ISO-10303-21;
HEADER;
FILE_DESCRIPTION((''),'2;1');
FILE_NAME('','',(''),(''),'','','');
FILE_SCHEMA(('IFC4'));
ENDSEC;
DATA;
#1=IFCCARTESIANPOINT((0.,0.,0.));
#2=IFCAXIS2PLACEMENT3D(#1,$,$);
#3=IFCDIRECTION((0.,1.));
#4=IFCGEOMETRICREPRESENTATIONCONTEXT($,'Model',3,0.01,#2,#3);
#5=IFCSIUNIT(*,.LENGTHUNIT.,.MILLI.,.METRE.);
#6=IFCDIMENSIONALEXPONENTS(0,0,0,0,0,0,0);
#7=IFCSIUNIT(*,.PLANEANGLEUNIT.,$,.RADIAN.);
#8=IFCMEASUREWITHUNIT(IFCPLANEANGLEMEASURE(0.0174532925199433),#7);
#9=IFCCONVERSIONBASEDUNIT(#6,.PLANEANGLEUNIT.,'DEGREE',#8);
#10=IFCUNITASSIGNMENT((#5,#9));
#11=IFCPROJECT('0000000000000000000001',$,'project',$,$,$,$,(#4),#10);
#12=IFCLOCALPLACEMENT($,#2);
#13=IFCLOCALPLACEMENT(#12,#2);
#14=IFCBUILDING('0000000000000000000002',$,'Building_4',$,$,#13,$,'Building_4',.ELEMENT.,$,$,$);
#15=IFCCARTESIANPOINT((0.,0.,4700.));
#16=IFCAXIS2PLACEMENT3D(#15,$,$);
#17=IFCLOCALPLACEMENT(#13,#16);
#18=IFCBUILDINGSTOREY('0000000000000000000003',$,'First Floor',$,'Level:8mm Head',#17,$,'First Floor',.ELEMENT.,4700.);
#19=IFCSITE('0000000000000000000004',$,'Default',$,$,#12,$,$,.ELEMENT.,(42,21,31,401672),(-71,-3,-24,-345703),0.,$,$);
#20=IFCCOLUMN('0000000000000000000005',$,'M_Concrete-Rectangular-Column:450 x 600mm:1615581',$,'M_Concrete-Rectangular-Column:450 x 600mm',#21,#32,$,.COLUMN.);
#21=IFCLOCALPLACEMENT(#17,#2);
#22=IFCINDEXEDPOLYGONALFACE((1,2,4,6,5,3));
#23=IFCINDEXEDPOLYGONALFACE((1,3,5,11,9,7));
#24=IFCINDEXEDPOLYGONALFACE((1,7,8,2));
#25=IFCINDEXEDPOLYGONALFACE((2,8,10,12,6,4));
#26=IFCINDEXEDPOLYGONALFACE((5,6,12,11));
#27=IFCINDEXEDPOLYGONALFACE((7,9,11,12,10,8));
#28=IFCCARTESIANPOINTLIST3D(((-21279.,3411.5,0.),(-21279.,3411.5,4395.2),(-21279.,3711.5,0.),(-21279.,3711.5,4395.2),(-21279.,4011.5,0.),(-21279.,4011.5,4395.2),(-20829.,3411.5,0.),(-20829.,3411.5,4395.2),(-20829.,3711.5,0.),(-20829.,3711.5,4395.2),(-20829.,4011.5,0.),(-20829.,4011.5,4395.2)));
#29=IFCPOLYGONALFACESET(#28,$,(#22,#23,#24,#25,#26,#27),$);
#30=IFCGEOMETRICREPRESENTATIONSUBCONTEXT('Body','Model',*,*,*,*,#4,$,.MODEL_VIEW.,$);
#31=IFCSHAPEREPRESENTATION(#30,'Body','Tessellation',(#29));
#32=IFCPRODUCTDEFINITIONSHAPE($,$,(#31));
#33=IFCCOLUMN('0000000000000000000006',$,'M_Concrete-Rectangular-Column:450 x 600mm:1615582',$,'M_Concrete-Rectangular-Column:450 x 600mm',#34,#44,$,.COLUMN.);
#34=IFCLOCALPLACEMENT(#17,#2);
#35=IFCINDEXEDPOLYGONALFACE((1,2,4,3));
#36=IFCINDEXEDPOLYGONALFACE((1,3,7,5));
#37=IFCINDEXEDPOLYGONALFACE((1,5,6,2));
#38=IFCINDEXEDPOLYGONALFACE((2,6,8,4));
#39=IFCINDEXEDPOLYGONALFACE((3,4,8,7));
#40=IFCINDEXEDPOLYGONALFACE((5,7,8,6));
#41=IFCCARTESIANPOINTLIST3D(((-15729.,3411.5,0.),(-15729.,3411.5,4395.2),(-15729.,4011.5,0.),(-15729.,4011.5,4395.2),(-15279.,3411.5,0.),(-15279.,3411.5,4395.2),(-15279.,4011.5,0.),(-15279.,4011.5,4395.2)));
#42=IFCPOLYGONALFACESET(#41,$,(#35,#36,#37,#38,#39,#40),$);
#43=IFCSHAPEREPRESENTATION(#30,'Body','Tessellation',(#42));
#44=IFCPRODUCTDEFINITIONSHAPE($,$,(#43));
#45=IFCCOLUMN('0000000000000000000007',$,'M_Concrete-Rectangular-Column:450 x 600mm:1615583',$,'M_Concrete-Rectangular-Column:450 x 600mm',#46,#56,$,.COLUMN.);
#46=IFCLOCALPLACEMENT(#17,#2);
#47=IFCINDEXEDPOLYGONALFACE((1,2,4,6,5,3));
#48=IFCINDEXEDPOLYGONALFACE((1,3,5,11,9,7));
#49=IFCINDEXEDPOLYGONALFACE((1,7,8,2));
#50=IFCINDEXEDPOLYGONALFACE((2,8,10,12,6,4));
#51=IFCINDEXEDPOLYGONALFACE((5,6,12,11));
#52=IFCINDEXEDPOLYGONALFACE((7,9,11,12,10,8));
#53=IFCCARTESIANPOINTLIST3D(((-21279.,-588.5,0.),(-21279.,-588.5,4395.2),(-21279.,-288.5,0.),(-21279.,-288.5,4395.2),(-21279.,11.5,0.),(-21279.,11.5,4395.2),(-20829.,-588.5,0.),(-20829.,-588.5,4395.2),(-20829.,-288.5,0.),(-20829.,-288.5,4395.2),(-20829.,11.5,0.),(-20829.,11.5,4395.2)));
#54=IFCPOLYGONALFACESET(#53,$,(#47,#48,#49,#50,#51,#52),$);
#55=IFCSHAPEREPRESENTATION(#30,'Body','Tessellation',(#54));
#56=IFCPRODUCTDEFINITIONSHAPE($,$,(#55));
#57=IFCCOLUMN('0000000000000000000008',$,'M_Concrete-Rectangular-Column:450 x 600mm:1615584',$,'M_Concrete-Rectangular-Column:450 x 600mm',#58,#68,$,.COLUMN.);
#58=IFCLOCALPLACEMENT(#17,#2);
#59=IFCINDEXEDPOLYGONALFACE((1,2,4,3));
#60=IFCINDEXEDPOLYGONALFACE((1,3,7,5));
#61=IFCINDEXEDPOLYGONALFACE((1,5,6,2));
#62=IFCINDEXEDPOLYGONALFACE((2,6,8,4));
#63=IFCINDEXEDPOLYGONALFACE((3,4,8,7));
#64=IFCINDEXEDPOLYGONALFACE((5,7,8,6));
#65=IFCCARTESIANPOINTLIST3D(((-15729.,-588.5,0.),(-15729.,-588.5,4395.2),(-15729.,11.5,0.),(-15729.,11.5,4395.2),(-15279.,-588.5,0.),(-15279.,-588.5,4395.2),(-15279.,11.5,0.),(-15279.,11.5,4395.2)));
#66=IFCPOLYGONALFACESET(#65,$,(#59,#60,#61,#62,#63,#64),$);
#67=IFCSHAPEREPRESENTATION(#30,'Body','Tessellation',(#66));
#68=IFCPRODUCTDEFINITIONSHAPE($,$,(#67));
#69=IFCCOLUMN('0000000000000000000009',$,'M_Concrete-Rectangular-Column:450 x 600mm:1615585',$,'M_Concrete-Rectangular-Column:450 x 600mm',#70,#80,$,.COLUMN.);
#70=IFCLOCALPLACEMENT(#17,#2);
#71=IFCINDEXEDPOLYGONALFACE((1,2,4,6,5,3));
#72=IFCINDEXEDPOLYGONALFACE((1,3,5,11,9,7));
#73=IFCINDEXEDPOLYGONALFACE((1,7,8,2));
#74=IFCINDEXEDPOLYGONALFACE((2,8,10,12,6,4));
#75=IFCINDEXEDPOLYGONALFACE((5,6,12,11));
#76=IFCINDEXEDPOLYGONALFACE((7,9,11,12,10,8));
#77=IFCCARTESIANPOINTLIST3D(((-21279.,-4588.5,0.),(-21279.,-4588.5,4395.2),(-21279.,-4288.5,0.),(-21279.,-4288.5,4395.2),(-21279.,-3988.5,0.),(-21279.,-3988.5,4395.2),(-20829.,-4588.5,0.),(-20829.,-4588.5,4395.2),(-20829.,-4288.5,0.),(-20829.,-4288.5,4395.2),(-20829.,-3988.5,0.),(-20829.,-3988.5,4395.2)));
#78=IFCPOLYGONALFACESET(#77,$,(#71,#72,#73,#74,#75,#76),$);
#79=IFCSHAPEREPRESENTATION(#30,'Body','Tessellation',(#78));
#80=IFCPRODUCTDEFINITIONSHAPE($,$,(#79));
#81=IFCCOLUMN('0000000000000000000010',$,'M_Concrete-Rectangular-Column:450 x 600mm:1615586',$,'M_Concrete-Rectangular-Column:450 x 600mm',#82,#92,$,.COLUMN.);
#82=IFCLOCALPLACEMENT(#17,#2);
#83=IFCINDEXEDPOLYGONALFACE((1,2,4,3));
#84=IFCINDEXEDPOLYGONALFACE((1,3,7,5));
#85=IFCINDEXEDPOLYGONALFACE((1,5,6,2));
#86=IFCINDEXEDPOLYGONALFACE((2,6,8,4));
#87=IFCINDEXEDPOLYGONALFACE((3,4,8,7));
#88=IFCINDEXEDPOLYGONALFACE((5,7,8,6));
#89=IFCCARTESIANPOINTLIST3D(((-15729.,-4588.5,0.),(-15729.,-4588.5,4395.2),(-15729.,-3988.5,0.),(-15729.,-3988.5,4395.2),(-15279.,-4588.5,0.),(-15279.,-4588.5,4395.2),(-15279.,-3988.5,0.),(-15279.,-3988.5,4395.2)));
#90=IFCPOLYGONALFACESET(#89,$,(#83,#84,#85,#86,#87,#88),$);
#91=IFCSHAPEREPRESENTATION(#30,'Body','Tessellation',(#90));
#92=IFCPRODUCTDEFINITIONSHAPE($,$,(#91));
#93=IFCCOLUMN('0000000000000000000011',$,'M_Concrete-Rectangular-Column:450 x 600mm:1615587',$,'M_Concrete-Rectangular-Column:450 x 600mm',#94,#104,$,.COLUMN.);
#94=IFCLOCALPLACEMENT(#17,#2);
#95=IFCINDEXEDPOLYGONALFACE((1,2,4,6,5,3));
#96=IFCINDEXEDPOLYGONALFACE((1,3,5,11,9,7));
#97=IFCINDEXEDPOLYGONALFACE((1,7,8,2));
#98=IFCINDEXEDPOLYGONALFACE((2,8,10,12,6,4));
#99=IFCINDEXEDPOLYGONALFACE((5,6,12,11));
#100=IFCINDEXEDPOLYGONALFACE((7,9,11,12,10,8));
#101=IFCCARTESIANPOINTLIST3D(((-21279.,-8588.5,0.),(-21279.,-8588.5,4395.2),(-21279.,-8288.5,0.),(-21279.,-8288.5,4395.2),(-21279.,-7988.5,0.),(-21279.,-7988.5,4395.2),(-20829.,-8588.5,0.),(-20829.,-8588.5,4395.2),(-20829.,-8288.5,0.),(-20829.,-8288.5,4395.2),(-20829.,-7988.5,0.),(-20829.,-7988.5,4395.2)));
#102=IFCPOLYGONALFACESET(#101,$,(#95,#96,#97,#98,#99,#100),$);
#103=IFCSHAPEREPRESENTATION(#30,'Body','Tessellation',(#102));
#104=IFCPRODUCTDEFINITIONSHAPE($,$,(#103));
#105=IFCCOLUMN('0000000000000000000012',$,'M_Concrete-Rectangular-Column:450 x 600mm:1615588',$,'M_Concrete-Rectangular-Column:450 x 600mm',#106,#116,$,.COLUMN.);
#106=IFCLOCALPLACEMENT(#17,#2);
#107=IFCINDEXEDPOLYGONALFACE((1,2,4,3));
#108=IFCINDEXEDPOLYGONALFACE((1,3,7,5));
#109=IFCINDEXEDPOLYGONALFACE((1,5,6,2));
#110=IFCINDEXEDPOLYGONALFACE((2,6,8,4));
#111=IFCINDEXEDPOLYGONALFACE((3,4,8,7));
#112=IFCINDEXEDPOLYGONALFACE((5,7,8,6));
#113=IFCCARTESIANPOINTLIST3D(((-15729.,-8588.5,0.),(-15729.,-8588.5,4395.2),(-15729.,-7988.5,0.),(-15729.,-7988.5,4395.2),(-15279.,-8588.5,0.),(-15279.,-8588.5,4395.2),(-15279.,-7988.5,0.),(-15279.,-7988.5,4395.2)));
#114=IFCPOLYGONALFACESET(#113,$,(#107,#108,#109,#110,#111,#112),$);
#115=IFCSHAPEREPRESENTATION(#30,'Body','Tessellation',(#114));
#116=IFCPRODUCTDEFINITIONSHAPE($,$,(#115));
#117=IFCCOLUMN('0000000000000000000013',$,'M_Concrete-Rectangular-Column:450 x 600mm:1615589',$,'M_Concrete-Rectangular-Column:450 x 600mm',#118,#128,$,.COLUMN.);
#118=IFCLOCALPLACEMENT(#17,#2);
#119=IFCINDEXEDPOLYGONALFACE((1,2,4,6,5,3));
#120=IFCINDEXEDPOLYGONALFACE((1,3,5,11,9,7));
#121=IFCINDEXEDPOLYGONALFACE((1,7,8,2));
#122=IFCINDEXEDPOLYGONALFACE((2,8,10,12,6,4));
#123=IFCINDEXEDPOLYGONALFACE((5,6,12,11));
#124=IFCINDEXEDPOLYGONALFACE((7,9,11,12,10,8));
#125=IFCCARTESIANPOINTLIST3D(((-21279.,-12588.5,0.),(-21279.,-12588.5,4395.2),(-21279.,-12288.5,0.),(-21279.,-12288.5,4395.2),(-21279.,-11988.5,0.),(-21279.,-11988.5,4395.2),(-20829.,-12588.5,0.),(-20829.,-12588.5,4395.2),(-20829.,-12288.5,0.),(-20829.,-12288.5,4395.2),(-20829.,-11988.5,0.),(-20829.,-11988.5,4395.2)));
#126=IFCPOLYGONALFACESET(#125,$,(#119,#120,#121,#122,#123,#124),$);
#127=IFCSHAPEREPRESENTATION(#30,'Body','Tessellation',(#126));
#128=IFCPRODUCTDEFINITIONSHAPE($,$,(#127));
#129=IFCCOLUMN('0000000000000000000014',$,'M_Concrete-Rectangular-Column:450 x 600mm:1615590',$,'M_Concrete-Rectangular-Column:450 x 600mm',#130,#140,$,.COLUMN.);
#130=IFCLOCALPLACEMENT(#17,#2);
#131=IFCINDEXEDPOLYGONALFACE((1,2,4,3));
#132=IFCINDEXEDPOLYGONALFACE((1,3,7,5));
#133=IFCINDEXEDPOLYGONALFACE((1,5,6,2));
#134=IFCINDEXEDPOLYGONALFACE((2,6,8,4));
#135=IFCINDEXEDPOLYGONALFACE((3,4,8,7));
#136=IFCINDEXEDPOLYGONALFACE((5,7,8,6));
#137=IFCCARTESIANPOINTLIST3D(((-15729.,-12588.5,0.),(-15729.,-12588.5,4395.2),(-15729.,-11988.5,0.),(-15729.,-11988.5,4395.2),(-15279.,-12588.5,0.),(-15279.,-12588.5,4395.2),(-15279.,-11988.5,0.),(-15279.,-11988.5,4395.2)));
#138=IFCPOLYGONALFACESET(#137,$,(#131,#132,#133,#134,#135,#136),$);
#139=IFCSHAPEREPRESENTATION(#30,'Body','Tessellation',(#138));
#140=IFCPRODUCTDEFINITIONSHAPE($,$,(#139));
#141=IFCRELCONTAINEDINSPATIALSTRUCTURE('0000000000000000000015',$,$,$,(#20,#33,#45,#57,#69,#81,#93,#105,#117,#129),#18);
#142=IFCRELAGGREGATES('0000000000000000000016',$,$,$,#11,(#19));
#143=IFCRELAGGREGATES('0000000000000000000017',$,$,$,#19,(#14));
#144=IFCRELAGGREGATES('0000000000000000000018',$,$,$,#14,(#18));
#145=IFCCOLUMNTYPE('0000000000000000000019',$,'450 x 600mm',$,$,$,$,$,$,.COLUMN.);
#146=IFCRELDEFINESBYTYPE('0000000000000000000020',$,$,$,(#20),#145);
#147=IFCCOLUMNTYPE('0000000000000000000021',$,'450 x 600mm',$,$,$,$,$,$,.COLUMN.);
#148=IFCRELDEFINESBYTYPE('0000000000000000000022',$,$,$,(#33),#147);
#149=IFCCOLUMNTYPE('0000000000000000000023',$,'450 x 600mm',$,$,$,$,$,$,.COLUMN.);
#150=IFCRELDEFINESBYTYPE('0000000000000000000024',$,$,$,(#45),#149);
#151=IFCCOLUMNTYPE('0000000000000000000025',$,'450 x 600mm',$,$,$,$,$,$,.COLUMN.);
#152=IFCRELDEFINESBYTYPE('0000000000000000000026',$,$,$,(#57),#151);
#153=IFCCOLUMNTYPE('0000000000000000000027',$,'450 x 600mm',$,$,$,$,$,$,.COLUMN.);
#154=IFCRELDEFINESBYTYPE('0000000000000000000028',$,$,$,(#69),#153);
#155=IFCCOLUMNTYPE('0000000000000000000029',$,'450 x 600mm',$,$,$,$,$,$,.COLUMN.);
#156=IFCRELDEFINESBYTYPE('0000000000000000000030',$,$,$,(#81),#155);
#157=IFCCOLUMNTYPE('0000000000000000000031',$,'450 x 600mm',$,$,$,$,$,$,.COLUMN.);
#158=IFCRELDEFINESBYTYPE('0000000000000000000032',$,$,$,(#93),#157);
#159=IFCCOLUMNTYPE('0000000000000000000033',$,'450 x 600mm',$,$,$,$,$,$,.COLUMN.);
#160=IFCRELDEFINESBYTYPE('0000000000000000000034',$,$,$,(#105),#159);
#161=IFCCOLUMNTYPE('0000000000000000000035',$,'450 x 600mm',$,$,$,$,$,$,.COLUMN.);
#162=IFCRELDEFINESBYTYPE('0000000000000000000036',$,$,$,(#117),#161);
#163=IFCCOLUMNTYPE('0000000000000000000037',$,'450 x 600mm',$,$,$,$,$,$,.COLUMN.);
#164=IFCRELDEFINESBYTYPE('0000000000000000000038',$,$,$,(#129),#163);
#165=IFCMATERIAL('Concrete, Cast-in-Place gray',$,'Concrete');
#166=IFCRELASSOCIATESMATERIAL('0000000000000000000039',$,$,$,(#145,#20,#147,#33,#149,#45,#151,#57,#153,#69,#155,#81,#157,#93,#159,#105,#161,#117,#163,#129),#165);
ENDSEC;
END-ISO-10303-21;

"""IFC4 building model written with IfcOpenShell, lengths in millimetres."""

from ifc_helpers import new_model, entity, si_unit, converted_unit, direction, frame, origin, place, context, subcontext, project, spatial, indexed_curve, outline, extrude, source, transform, mapped, material, type_object, type_shapes, element, save


model = new_model("IFC4")

# Units and contexts
model_context = context("Model", 3, precision=0.01, world=origin(), true_north=direction((0.0, 1.0)))
body_context = subcontext(model_context, "Body", "Model", "MODEL_VIEW")
ifc_project = project(units=[si_unit("LENGTHUNIT", "METRE", prefix="MILLI"), converted_unit("PLANEANGLEUNIT", "DEGREE", entity("IfcPlaneAngleMeasure", 0.0174532925199433), si_unit("PLANEANGLEUNIT", "RADIAN"), dimensions=[0, 0, 0, 0, 0, 0, 0])], contexts=[model_context])

# Site, building, storey
site_placement = place(None, origin())
site = spatial("IfcSite", under=ifc_project, at=site_placement, Name="Default", CompositionType="ELEMENT", RefLatitude=(42, 21, 31, 401672), RefLongitude=(-71, -3, -24, -345703), RefElevation=0.0)
building_placement = place(site_placement, origin())
building = spatial("IfcBuilding", under=site, at=building_placement, Name="Building_4", LongName="Building_4", CompositionType="ELEMENT")
storey_placement = place(building_placement, frame((0.0, 0.0, 4700.0)))
storey = spatial("IfcBuildingStorey", under=building, at=storey_placement, Name="First Floor", ObjectType="Level:8mm Head", LongName="First Floor", CompositionType="ELEMENT", Elevation=4700.0)

# Columns
ifc_material = material(Name="Concrete, Cast-in-Place gray", Category="Concrete")
column_type_1 = type_object("IfcColumnType", Name="450 x 600mm", PredefinedType="COLUMN", material=ifc_material)
shared_shape_1 = source(origin(), body_context, "Body", "SweptSolid", [
    extrude(outline(indexed_curve([(-2197.6, -300.0), (2197.6, -300.0), (2197.6, 0.0), (2197.6, 300.0), (-2197.6, 300.0), (-2197.6, 0.0), (-2197.6, -300.0)], self_intersect=False)), frame((-21279.0, 3711.5, 6897.6), z_axis=(1.0, 0.0, 0.0), x_axis=(0.0, 0.0, 1.0)), (0.0, 0.0, 1.0), 450.0),
])
type_shapes(column_type_1, [shared_shape_1])
column_1_placement = place(storey_placement, frame((0.0, 0.0, -4700.0)))
element("IfcColumn", 1, at=column_1_placement, inside=storey, type_object=column_type_1, material=ifc_material, Name="M_Concrete-Rectangular-Column:450 x 600mm:1615581", ObjectType="M_Concrete-Rectangular-Column:450 x 600mm", PredefinedType="COLUMN", context=body_context, shape_type="MappedRepresentation", body=[
    mapped(shared_shape_1, transform((0.0, 0.0, 0.0), scale=1.0)),
])
column_type_2 = type_object("IfcColumnType", Name="450 x 600mm", PredefinedType="COLUMN", material=ifc_material)
shared_shape_2 = source(origin(), body_context, "Body", "SweptSolid", [
    extrude(outline(indexed_curve([(-2197.6, -300.0), (2197.6, -300.0), (2197.6, 300.0), (-2197.6, 300.0), (-2197.6, -300.0)], self_intersect=False)), frame((-15729.0, 3711.5, 6897.6), z_axis=(1.0, 0.0, 0.0), x_axis=(0.0, 0.0, 1.0)), (0.0, 0.0, 1.0), 450.0),
])
type_shapes(column_type_2, [shared_shape_2])
column_2_placement = place(storey_placement, frame((0.0, 0.0, -4700.0)))
element("IfcColumn", 2, at=column_2_placement, inside=storey, type_object=column_type_2, material=ifc_material, Name="M_Concrete-Rectangular-Column:450 x 600mm:1615582", ObjectType="M_Concrete-Rectangular-Column:450 x 600mm", PredefinedType="COLUMN", context=body_context, shape_type="MappedRepresentation", body=[
    mapped(shared_shape_2, transform((0.0, 0.0, 0.0), scale=1.0)),
])
column_type_3 = type_object("IfcColumnType", Name="450 x 600mm", PredefinedType="COLUMN", material=ifc_material)
shared_shape_3 = source(origin(), body_context, "Body", "SweptSolid", [
    extrude(outline(indexed_curve([(-2197.6, -300.0), (2197.6, -300.0), (2197.6, 0.0), (2197.6, 300.0), (-2197.6, 300.0), (-2197.6, 0.0), (-2197.6, -300.0)], self_intersect=False)), frame((-21279.0, -288.5, 6897.6), z_axis=(1.0, 0.0, 0.0), x_axis=(0.0, 0.0, 1.0)), (0.0, 0.0, 1.0), 450.0),
])
type_shapes(column_type_3, [shared_shape_3])
column_3_placement = place(storey_placement, frame((0.0, 0.0, -4700.0)))
element("IfcColumn", 3, at=column_3_placement, inside=storey, type_object=column_type_3, material=ifc_material, Name="M_Concrete-Rectangular-Column:450 x 600mm:1615583", ObjectType="M_Concrete-Rectangular-Column:450 x 600mm", PredefinedType="COLUMN", context=body_context, shape_type="MappedRepresentation", body=[
    mapped(shared_shape_3, transform((0.0, 0.0, 0.0), scale=1.0)),
])
column_type_4 = type_object("IfcColumnType", Name="450 x 600mm", PredefinedType="COLUMN", material=ifc_material)
shared_shape_4 = source(origin(), body_context, "Body", "SweptSolid", [
    extrude(outline(indexed_curve([(-2197.6, -300.0), (2197.6, -300.0), (2197.6, 300.0), (-2197.6, 300.0), (-2197.6, -300.0)], self_intersect=False)), frame((-15729.0, -288.5, 6897.6), z_axis=(1.0, 0.0, 0.0), x_axis=(0.0, 0.0, 1.0)), (0.0, 0.0, 1.0), 450.0),
])
type_shapes(column_type_4, [shared_shape_4])
column_4_placement = place(storey_placement, frame((0.0, 0.0, -4700.0)))
element("IfcColumn", 4, at=column_4_placement, inside=storey, type_object=column_type_4, material=ifc_material, Name="M_Concrete-Rectangular-Column:450 x 600mm:1615584", ObjectType="M_Concrete-Rectangular-Column:450 x 600mm", PredefinedType="COLUMN", context=body_context, shape_type="MappedRepresentation", body=[
    mapped(shared_shape_4, transform((0.0, 0.0, 0.0), scale=1.0)),
])
column_type_5 = type_object("IfcColumnType", Name="450 x 600mm", PredefinedType="COLUMN", material=ifc_material)
shared_shape_5 = source(origin(), body_context, "Body", "SweptSolid", [
    extrude(outline(indexed_curve([(-2197.6, -300.0), (2197.6, -300.0), (2197.6, 0.0), (2197.6, 300.0), (-2197.6, 300.0), (-2197.6, 0.0), (-2197.6, -300.0)], self_intersect=False)), frame((-21279.0, -4288.5, 6897.6), z_axis=(1.0, 0.0, 0.0), x_axis=(0.0, 0.0, 1.0)), (0.0, 0.0, 1.0), 450.0),
])
type_shapes(column_type_5, [shared_shape_5])
column_5_placement = place(storey_placement, frame((0.0, 0.0, -4700.0)))
element("IfcColumn", 5, at=column_5_placement, inside=storey, type_object=column_type_5, material=ifc_material, Name="M_Concrete-Rectangular-Column:450 x 600mm:1615585", ObjectType="M_Concrete-Rectangular-Column:450 x 600mm", PredefinedType="COLUMN", context=body_context, shape_type="MappedRepresentation", body=[
    mapped(shared_shape_5, transform((0.0, 0.0, 0.0), scale=1.0)),
])
column_type_6 = type_object("IfcColumnType", Name="450 x 600mm", PredefinedType="COLUMN", material=ifc_material)
shared_shape_6 = source(origin(), body_context, "Body", "SweptSolid", [
    extrude(outline(indexed_curve([(-2197.6, -300.0), (2197.6, -300.0), (2197.6, 300.0), (-2197.6, 300.0), (-2197.6, -300.0)], self_intersect=False)), frame((-15729.0, -4288.5, 6897.6), z_axis=(1.0, 0.0, 0.0), x_axis=(0.0, 0.0, 1.0)), (0.0, 0.0, 1.0), 450.0),
])
type_shapes(column_type_6, [shared_shape_6])
column_6_placement = place(storey_placement, frame((0.0, 0.0, -4700.0)))
element("IfcColumn", 6, at=column_6_placement, inside=storey, type_object=column_type_6, material=ifc_material, Name="M_Concrete-Rectangular-Column:450 x 600mm:1615586", ObjectType="M_Concrete-Rectangular-Column:450 x 600mm", PredefinedType="COLUMN", context=body_context, shape_type="MappedRepresentation", body=[
    mapped(shared_shape_6, transform((0.0, 0.0, 0.0), scale=1.0)),
])
column_type_7 = type_object("IfcColumnType", Name="450 x 600mm", PredefinedType="COLUMN", material=ifc_material)
shared_shape_7 = source(origin(), body_context, "Body", "SweptSolid", [
    extrude(outline(indexed_curve([(-2197.6, -300.0), (2197.6, -300.0), (2197.6, 0.0), (2197.6, 300.0), (-2197.6, 300.0), (-2197.6, 0.0), (-2197.6, -300.0)], self_intersect=False)), frame((-21279.0, -8288.5, 6897.6), z_axis=(1.0, 0.0, 0.0), x_axis=(0.0, 0.0, 1.0)), (0.0, 0.0, 1.0), 450.0),
])
type_shapes(column_type_7, [shared_shape_7])
column_7_placement = place(storey_placement, frame((0.0, 0.0, -4700.0)))
element("IfcColumn", 7, at=column_7_placement, inside=storey, type_object=column_type_7, material=ifc_material, Name="M_Concrete-Rectangular-Column:450 x 600mm:1615587", ObjectType="M_Concrete-Rectangular-Column:450 x 600mm", PredefinedType="COLUMN", context=body_context, shape_type="MappedRepresentation", body=[
    mapped(shared_shape_7, transform((0.0, 0.0, 0.0), scale=1.0)),
])
column_type_8 = type_object("IfcColumnType", Name="450 x 600mm", PredefinedType="COLUMN", material=ifc_material)
shared_shape_8 = source(origin(), body_context, "Body", "SweptSolid", [
    extrude(outline(indexed_curve([(-2197.6, -300.0), (2197.6, -300.0), (2197.6, 300.0), (-2197.6, 300.0), (-2197.6, -300.0)], self_intersect=False)), frame((-15729.0, -8288.5, 6897.6), z_axis=(1.0, 0.0, 0.0), x_axis=(0.0, 0.0, 1.0)), (0.0, 0.0, 1.0), 450.0),
])
type_shapes(column_type_8, [shared_shape_8])
column_8_placement = place(storey_placement, frame((0.0, 0.0, -4700.0)))
element("IfcColumn", 8, at=column_8_placement, inside=storey, type_object=column_type_8, material=ifc_material, Name="M_Concrete-Rectangular-Column:450 x 600mm:1615588", ObjectType="M_Concrete-Rectangular-Column:450 x 600mm", PredefinedType="COLUMN", context=body_context, shape_type="MappedRepresentation", body=[
    mapped(shared_shape_8, transform((0.0, 0.0, 0.0), scale=1.0)),
])
column_type_9 = type_object("IfcColumnType", Name="450 x 600mm", PredefinedType="COLUMN", material=ifc_material)
shared_shape_9 = source(origin(), body_context, "Body", "SweptSolid", [
    extrude(outline(indexed_curve([(-2197.6, -300.0), (2197.6, -300.0), (2197.6, 0.0), (2197.6, 300.0), (-2197.6, 300.0), (-2197.6, 0.0), (-2197.6, -300.0)], self_intersect=False)), frame((-21279.0, -12288.5, 6897.6), z_axis=(1.0, 0.0, 0.0), x_axis=(0.0, 0.0, 1.0)), (0.0, 0.0, 1.0), 450.0),
])
type_shapes(column_type_9, [shared_shape_9])
column_9_placement = place(storey_placement, frame((0.0, 0.0, -4700.0)))
element("IfcColumn", 9, at=column_9_placement, inside=storey, type_object=column_type_9, material=ifc_material, Name="M_Concrete-Rectangular-Column:450 x 600mm:1615589", ObjectType="M_Concrete-Rectangular-Column:450 x 600mm", PredefinedType="COLUMN", context=body_context, shape_type="MappedRepresentation", body=[
    mapped(shared_shape_9, transform((0.0, 0.0, 0.0), scale=1.0)),
])
column_type_10 = type_object("IfcColumnType", Name="450 x 600mm", PredefinedType="COLUMN", material=ifc_material)
shared_shape_10 = source(origin(), body_context, "Body", "SweptSolid", [
    extrude(outline(indexed_curve([(-2197.6, -300.0), (2197.6, -300.0), (2197.6, 300.0), (-2197.6, 300.0), (-2197.6, -300.0)], self_intersect=False)), frame((-15729.0, -12288.5, 6897.6), z_axis=(1.0, 0.0, 0.0), x_axis=(0.0, 0.0, 1.0)), (0.0, 0.0, 1.0), 450.0),
])
type_shapes(column_type_10, [shared_shape_10])
column_10_placement = place(storey_placement, frame((0.0, 0.0, -4700.0)))
element("IfcColumn", 10, at=column_10_placement, inside=storey, type_object=column_type_10, material=ifc_material, Name="M_Concrete-Rectangular-Column:450 x 600mm:1615590", ObjectType="M_Concrete-Rectangular-Column:450 x 600mm", PredefinedType="COLUMN", context=body_context, shape_type="MappedRepresentation", body=[
    mapped(shared_shape_10, transform((0.0, 0.0, 0.0), scale=1.0)),
])

save(model, "model.ifc")
